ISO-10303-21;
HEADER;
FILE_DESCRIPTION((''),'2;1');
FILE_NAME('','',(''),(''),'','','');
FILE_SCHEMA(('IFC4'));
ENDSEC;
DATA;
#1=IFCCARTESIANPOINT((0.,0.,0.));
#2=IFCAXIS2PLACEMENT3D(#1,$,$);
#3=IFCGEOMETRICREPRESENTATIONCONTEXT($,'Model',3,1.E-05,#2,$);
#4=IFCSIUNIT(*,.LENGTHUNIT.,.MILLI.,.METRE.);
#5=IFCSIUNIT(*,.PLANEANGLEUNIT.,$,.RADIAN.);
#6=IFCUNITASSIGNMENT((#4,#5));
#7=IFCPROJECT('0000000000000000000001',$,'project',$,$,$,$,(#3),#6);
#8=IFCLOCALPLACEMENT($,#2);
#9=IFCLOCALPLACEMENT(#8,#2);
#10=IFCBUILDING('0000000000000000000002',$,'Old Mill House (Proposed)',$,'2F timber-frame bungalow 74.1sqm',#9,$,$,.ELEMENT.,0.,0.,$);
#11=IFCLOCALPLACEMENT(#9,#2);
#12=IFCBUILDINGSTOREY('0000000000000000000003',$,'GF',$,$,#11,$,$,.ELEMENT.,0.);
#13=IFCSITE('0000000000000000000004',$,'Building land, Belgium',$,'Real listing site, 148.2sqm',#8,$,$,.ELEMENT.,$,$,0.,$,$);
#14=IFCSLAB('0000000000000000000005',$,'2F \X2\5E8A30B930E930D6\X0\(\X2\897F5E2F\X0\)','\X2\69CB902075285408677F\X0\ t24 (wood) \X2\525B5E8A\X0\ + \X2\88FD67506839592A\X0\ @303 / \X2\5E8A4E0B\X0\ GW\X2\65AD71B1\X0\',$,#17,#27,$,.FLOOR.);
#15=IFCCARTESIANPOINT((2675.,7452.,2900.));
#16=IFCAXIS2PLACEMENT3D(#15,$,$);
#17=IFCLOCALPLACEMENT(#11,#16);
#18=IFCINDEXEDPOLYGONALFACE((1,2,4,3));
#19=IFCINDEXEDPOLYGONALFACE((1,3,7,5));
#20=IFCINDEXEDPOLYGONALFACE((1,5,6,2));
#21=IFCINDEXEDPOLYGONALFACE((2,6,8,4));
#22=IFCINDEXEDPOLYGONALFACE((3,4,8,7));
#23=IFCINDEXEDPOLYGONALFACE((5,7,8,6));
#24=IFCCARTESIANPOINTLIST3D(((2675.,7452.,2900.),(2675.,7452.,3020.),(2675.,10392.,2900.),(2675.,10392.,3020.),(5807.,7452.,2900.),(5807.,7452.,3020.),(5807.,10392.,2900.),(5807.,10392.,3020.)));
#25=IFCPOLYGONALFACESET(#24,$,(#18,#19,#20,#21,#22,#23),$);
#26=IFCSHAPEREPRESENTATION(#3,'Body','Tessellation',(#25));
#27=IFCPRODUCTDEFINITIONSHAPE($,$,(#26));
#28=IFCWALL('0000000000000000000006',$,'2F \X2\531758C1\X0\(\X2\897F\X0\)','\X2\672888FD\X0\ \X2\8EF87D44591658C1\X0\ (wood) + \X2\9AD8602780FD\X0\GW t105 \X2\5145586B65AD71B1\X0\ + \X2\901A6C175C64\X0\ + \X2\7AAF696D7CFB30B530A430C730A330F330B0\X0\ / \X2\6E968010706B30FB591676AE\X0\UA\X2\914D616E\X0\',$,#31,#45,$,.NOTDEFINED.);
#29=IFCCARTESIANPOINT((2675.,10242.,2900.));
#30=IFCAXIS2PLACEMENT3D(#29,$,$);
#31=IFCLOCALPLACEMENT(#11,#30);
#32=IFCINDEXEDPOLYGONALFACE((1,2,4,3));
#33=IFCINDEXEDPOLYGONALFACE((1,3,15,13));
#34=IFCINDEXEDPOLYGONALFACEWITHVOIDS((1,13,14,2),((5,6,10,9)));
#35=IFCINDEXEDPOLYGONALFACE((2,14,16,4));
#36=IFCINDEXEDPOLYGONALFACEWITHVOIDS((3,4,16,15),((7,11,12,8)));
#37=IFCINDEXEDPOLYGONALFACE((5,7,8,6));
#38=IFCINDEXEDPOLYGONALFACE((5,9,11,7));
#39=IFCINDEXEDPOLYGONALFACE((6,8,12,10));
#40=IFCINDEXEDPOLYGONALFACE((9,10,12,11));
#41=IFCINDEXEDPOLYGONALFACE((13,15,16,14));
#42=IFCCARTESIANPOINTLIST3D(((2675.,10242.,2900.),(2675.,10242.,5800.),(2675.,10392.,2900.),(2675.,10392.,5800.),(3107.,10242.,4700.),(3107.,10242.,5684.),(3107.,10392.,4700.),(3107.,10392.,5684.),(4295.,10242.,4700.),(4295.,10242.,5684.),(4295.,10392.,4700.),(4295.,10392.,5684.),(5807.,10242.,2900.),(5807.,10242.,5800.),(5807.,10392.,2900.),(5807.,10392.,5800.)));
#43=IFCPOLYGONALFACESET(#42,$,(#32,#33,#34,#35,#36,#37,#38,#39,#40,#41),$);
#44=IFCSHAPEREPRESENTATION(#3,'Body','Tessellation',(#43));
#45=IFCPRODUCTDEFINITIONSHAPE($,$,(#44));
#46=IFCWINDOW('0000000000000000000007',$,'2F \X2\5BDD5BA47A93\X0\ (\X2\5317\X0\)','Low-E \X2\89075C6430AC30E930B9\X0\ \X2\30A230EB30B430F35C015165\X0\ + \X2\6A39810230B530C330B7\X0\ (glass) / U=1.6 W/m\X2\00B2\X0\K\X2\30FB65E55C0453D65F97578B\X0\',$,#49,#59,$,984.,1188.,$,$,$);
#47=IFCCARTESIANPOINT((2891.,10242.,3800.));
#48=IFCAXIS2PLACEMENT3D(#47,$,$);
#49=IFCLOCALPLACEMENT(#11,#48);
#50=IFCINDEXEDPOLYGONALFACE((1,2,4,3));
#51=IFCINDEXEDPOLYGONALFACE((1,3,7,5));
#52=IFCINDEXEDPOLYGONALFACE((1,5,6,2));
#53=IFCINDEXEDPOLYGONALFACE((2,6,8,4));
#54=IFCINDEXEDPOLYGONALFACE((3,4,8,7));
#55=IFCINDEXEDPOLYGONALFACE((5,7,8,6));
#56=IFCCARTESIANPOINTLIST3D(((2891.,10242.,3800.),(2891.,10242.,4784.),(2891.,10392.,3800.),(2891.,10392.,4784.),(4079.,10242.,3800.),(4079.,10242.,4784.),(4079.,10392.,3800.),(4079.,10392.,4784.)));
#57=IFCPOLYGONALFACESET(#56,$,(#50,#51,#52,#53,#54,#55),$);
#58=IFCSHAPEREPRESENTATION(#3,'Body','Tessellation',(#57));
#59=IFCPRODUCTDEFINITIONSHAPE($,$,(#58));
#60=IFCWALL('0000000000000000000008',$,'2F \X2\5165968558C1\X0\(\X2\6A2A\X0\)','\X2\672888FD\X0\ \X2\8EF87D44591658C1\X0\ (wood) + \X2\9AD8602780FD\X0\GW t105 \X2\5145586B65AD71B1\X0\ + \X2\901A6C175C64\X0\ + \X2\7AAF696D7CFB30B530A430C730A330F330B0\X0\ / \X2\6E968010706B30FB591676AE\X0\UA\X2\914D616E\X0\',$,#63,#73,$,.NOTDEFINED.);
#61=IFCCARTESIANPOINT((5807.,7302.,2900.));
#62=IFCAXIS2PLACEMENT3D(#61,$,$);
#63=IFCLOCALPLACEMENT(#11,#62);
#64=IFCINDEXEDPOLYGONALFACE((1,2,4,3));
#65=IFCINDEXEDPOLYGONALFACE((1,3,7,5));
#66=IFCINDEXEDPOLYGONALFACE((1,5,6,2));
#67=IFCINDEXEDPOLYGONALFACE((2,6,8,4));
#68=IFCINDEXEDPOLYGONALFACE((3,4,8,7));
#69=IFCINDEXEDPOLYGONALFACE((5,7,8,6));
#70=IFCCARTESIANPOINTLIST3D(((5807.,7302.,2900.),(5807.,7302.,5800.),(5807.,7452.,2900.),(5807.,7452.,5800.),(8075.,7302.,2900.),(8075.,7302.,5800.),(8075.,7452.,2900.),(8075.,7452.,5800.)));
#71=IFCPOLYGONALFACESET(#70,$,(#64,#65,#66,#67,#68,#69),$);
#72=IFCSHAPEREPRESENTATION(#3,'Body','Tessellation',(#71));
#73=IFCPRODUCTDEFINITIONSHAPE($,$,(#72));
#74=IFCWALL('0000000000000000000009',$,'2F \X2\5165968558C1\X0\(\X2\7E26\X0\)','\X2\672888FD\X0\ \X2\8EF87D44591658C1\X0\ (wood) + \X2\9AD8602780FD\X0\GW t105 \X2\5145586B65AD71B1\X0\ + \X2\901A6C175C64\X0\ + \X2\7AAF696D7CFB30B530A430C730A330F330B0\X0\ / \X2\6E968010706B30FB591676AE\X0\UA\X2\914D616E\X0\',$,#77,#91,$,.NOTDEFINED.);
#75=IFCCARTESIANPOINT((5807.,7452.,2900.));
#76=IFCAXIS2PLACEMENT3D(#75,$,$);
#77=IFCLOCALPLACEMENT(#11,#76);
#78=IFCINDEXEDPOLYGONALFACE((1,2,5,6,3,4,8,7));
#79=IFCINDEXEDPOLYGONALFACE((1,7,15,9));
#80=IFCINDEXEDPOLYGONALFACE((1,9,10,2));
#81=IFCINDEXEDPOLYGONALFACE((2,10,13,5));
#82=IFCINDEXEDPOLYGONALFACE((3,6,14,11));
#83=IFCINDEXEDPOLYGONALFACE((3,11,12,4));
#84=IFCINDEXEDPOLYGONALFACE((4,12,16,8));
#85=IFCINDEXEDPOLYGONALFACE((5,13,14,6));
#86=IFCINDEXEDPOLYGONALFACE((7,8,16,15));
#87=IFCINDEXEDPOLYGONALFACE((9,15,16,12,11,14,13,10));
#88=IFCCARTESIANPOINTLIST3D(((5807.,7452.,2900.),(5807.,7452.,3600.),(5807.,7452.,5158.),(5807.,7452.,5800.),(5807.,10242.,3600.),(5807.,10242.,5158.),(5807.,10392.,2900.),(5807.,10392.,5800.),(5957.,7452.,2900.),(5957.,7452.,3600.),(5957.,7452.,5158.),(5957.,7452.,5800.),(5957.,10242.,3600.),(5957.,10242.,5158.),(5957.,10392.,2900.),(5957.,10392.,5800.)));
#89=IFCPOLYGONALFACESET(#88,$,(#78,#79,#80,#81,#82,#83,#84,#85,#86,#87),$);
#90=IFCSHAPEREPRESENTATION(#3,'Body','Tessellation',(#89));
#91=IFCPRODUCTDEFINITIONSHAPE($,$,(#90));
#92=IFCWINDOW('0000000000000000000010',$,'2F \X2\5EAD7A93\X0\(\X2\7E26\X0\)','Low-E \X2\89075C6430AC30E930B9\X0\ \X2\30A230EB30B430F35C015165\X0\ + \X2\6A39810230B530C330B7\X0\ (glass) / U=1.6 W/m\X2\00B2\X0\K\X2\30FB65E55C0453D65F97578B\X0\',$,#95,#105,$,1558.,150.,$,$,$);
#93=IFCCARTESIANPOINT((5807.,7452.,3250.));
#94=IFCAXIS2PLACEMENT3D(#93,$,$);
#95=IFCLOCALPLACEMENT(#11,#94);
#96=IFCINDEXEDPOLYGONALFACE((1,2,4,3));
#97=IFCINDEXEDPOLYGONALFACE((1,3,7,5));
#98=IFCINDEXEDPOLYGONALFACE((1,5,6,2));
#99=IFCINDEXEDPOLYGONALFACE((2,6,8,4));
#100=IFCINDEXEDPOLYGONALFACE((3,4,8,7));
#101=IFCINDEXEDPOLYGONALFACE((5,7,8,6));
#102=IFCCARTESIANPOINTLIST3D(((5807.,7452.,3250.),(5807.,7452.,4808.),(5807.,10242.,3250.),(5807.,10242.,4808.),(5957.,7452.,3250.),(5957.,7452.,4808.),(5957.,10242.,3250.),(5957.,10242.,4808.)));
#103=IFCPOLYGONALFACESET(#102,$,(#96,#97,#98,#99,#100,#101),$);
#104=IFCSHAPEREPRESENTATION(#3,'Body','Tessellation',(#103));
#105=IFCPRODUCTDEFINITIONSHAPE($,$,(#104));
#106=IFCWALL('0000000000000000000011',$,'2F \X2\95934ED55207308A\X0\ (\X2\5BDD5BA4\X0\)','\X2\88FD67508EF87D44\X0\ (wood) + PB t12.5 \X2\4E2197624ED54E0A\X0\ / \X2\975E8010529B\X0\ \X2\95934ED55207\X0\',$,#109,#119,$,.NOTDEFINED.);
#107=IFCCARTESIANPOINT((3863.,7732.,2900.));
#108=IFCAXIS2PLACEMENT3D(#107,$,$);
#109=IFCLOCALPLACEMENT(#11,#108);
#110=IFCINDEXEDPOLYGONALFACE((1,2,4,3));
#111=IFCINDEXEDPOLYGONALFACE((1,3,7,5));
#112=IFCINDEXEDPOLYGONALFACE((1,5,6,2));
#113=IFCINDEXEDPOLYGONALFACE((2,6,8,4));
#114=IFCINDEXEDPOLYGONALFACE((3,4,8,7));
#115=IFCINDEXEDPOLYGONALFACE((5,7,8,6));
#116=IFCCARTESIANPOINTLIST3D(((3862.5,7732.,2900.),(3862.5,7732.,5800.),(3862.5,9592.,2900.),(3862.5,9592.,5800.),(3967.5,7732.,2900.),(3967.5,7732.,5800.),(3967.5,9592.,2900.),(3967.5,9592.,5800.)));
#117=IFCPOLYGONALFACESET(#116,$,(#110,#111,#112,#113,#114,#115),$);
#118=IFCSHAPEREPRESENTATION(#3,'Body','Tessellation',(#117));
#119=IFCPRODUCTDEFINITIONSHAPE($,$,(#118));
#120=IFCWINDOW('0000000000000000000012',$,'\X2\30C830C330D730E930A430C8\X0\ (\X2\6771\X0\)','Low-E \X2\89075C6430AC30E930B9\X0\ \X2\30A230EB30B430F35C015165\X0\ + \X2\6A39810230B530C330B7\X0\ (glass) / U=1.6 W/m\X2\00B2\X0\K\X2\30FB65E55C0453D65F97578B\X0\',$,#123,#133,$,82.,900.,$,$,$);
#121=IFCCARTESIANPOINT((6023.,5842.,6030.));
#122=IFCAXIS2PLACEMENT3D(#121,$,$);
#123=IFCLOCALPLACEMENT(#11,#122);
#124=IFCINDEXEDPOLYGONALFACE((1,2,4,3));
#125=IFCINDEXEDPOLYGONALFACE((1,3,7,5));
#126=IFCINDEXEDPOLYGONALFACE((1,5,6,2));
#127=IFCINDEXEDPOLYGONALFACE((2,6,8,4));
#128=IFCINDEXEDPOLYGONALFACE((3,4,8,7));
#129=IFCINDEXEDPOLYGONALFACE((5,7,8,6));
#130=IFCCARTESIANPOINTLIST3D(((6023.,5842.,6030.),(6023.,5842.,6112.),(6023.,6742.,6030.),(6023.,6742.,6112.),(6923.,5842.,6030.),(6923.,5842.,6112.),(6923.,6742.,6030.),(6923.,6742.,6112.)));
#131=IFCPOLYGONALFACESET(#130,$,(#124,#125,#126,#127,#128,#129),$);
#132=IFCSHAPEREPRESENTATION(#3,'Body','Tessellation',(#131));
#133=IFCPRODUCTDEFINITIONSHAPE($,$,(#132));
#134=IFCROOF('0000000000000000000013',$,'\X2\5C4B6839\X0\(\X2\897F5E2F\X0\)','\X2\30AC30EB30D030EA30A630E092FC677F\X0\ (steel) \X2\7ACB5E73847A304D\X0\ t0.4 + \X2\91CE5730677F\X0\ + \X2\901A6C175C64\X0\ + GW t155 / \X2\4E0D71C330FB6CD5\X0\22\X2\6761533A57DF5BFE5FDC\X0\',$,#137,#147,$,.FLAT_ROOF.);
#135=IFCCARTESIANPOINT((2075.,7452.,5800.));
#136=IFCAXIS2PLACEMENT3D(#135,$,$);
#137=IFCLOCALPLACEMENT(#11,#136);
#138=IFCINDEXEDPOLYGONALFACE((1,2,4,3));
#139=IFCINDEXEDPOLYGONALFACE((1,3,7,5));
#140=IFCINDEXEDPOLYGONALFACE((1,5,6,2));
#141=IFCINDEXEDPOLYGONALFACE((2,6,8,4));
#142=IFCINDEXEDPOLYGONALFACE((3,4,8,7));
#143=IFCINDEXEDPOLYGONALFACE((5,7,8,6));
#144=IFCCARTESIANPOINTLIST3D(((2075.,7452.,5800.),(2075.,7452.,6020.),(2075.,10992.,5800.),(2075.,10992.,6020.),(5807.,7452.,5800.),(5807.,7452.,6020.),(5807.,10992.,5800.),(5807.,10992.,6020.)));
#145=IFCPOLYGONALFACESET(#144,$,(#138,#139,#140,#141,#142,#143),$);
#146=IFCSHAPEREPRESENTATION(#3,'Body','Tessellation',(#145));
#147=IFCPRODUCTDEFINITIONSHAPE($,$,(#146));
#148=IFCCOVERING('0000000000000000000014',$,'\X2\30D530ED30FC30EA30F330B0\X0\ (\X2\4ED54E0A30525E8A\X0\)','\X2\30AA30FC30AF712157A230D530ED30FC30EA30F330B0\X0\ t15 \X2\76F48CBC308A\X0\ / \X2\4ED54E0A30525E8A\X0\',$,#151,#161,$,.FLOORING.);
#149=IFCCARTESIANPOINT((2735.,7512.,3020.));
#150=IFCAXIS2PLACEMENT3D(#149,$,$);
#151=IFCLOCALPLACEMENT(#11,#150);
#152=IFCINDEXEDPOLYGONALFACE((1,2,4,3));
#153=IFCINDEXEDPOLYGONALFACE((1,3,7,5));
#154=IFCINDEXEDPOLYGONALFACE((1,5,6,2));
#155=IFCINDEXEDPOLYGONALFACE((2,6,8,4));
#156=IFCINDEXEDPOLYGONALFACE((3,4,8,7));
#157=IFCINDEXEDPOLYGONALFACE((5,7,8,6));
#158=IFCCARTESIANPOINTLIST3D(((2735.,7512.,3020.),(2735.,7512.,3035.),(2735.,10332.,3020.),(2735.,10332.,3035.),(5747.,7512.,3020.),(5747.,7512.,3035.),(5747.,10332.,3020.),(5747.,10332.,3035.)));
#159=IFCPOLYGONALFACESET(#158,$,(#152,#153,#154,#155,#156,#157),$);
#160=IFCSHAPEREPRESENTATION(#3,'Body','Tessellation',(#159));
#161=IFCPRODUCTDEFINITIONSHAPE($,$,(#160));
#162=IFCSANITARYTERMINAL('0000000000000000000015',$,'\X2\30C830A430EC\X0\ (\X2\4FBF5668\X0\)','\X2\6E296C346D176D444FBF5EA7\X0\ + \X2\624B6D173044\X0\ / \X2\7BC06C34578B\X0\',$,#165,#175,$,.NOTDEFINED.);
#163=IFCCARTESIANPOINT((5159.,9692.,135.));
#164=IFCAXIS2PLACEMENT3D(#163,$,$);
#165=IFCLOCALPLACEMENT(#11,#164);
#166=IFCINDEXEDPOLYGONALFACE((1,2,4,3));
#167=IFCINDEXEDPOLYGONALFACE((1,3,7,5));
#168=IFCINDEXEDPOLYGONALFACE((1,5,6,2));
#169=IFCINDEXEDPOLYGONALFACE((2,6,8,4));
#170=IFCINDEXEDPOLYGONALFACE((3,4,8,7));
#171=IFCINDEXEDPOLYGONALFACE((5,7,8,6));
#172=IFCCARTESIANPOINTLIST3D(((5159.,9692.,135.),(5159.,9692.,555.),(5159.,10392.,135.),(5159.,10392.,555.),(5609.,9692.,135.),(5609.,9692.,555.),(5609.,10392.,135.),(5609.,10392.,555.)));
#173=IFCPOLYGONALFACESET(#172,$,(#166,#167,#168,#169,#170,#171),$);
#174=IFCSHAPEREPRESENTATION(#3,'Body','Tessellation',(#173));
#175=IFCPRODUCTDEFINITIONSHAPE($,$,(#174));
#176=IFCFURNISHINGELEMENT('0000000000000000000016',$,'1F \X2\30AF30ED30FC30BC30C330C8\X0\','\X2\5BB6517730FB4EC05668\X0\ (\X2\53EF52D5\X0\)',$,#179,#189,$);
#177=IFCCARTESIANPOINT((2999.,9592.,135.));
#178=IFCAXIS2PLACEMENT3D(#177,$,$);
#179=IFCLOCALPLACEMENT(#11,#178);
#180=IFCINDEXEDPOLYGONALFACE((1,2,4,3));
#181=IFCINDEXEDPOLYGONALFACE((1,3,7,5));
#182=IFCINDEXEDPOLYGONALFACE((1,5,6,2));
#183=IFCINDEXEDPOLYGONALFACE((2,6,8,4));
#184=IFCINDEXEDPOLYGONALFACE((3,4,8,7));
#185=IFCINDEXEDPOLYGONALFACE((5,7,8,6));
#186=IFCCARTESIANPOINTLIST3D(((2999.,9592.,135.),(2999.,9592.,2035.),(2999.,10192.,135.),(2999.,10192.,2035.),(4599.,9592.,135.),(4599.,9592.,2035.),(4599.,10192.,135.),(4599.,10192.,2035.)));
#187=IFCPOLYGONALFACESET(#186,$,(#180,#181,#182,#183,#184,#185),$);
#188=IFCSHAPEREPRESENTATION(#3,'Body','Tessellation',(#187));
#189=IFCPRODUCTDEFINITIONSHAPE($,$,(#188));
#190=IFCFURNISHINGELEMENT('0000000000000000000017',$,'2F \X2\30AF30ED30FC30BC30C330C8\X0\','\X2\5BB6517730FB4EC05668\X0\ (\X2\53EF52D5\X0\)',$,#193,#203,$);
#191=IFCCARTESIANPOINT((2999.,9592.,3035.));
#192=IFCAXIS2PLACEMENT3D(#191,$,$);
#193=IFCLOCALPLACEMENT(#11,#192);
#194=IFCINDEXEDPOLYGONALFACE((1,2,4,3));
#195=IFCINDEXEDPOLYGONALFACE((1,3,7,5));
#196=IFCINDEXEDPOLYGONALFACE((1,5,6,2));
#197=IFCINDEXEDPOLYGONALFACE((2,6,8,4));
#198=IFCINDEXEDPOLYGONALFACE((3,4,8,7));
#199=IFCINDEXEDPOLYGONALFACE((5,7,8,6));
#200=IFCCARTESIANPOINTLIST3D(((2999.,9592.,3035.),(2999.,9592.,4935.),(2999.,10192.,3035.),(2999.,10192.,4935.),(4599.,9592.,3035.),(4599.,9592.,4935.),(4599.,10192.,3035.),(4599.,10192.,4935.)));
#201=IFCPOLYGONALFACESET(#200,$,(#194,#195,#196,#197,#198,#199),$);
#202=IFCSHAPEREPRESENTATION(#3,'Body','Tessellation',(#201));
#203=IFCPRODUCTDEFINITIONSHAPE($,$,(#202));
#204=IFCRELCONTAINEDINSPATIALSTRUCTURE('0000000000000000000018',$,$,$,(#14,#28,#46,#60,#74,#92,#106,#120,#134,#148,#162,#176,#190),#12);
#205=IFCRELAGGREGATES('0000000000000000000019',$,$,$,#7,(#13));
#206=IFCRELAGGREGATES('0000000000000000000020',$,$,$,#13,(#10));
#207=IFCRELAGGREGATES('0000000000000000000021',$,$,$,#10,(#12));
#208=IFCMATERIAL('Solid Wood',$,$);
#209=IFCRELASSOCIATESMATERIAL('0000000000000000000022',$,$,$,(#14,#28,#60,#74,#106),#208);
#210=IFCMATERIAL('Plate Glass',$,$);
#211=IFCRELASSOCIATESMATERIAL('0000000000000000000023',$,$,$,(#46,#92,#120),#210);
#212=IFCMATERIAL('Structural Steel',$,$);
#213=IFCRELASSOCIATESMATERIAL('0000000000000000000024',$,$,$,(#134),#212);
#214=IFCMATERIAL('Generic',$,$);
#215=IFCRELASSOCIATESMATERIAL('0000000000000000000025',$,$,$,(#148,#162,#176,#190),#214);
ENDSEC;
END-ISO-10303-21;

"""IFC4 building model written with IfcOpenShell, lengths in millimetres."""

from ifc_helpers import new_model, si_unit, frame, frame_2d, origin, place, context, project, spatial, rectangle, extrude, material, element, fill, save


model = new_model("IFC4")

# Units and contexts
model_context = context("Model", 3, precision=1e-05, world=origin())
ifc_project = project(units=[si_unit("LENGTHUNIT", "METRE", prefix="MILLI"), si_unit("PLANEANGLEUNIT", "RADIAN")], contexts=[model_context])

# Site, building, storey
site_placement = place(None, origin())
site = spatial("IfcSite", under=ifc_project, at=site_placement, Name="Building land, Belgium", ObjectType="Real listing site, 148.2sqm", CompositionType="ELEMENT", RefElevation=0.0)
building_placement = place(site_placement, origin())
building = spatial("IfcBuilding", under=site, at=building_placement, Name="Old Mill House (Proposed)", ObjectType="2F timber-frame bungalow 74.1sqm", CompositionType="ELEMENT", ElevationOfRefHeight=0.0, ElevationOfTerrain=0.0)
storey_placement = place(building_placement, origin())
storey = spatial("IfcBuildingStorey", under=building, at=storey_placement, Name="GF", CompositionType="ELEMENT", Elevation=0.0)

# Slab
ifc_material_1 = material(Name="Solid Wood")
slab_placement = place(storey_placement, frame((2675.0, 7452.0, 2900.0)))
element("IfcSlab", 1, at=slab_placement, inside=storey, material=ifc_material_1, Name="2F 床スラブ(西帯)", Description="構造用合板 t24 (wood) 剛床 + 製材根太 @303 / 床下 GW断熱", PredefinedType="FLOOR", context=model_context, shape_type="SweptSolid", body=[
    extrude(rectangle(XDim=3132.0, YDim=2940.0, at=frame_2d((1566.0, 1470.0))), frame((2675.0, 7452.0, 2900.0)), (0.0, 0.0, 1.0), 120.0),
])

# Wall, opening, window
wall_1_placement = place(storey_placement, frame((2675.0, 10242.0, 2900.0)))
wall_1 = element("IfcWall", 2, at=wall_1_placement, inside=storey, material=ifc_material_1, Name="2F 北壁(西)", Description="木製 軸組外壁 (wood) + 高性能GW t105 充填断熱 + 通気層 + 窯業系サイディング / 準耐火・外皮UA配慮", PredefinedType="NOTDEFINED", context=model_context, shape_type="SweptSolid", body=[
    extrude(rectangle(XDim=3132.0, YDim=150.0, at=frame_2d((1566.0, 75.0))), frame((2675.0, 10242.0, 2900.0)), (0.0, 0.0, 1.0), 2900.0),
])
opening_1_placement = place(storey_placement, frame((2891.0, 10242.0, 3800.0)))
opening_1 = element("IfcOpeningElement", 3, at=opening_1_placement, cuts=wall_1, PredefinedType="NOTDEFINED", context=model_context, shape_type="SweptSolid", body=[
    extrude(rectangle(XDim=1188.0, YDim=150.0, at=frame_2d((594.0, 75.0))), frame((2891.0, 10242.0, 3800.0)), (0.0, 0.0, 1.0), 984.0),
])
ifc_material_2 = material(Name="Plate Glass")
window_1_placement = place(storey_placement, frame((2891.0, 10242.0, 3800.0)))
window_1 = element("IfcWindow", 4, at=window_1_placement, inside=storey, material=ifc_material_2, Name="2F 寝室窓 (北)", Description="Low-E 複層ガラス アルゴン封入 + 樹脂サッシ (glass) / U=1.6 W/m²K・日射取得型", OverallHeight=984.0, OverallWidth=1188.0, context=model_context, shape_type="SweptSolid", body=[
    extrude(rectangle(XDim=1188.0, YDim=150.0, at=frame_2d((594.0, 75.0))), frame((2891.0, 10242.0, 3800.0)), (0.0, 0.0, 1.0), 984.0),
])
fill(opening_1, window_1)

# Wall
wall_2_placement = place(storey_placement, frame((5807.0, 7302.0, 2900.0)))
element("IfcWall", 5, at=wall_2_placement, inside=storey, material=ifc_material_1, Name="2F 入隅壁(横)", Description="木製 軸組外壁 (wood) + 高性能GW t105 充填断熱 + 通気層 + 窯業系サイディング / 準耐火・外皮UA配慮", PredefinedType="NOTDEFINED", context=model_context, shape_type="SweptSolid", body=[
    extrude(rectangle(XDim=2268.0, YDim=150.0, at=frame_2d((1134.0, 75.0))), frame((5807.0, 7302.0, 2900.0)), (0.0, 0.0, 1.0), 2900.0),
])

# Wall, opening, window
wall_3_placement = place(storey_placement, frame((5807.0, 7452.0, 2900.0)))
wall_3 = element("IfcWall", 6, at=wall_3_placement, inside=storey, material=ifc_material_1, Name="2F 入隅壁(縦)", Description="木製 軸組外壁 (wood) + 高性能GW t105 充填断熱 + 通気層 + 窯業系サイディング / 準耐火・外皮UA配慮", PredefinedType="NOTDEFINED", context=model_context, shape_type="SweptSolid", body=[
    extrude(rectangle(XDim=150.0, YDim=2940.0, at=frame_2d((75.0, 1470.0))), frame((5807.0, 7452.0, 2900.0)), (0.0, 0.0, 1.0), 2900.0),
])
opening_2_placement = place(storey_placement, frame((5807.0, 7452.0, 3250.0)))
opening_2 = element("IfcOpeningElement", 7, at=opening_2_placement, cuts=wall_3, PredefinedType="NOTDEFINED", context=model_context, shape_type="SweptSolid", body=[
    extrude(rectangle(XDim=150.0, YDim=2790.0, at=frame_2d((75.0, 1395.0))), frame((5807.0, 7452.0, 3250.0)), (0.0, 0.0, 1.0), 1558.0),
])
window_2_placement = place(storey_placement, frame((5807.0, 7452.0, 3250.0)))
window_2 = element("IfcWindow", 8, at=window_2_placement, inside=storey, material=ifc_material_2, Name="2F 庭窓(縦)", Description="Low-E 複層ガラス アルゴン封入 + 樹脂サッシ (glass) / U=1.6 W/m²K・日射取得型", OverallHeight=1558.0, OverallWidth=150.0, context=model_context, shape_type="SweptSolid", body=[
    extrude(rectangle(XDim=150.0, YDim=2790.0, at=frame_2d((75.0, 1395.0))), frame((5807.0, 7452.0, 3250.0)), (0.0, 0.0, 1.0), 1558.0),
])
fill(opening_2, window_2)

# Wall
wall_4_placement = place(storey_placement, frame((3863.0, 7732.0, 2900.0)))
element("IfcWall", 9, at=wall_4_placement, inside=storey, material=ifc_material_1, Name="2F 間仕切り (寝室)", Description="製材軸組 (wood) + PB t12.5 両面仕上 / 非耐力 間仕切", PredefinedType="NOTDEFINED", context=model_context, shape_type="SweptSolid", body=[
    extrude(rectangle(XDim=105.0, YDim=1860.0, at=frame_2d((52.0, 930.0))), frame((3863.0, 7732.0, 2900.0)), (0.0, 0.0, 1.0), 2900.0),
])

# Window
window_3_placement = place(storey_placement, frame((6023.0, 5842.0, 6030.0)))
element("IfcWindow", 10, at=window_3_placement, inside=storey, material=ifc_material_2, Name="トップライト (東)", Description="Low-E 複層ガラス アルゴン封入 + 樹脂サッシ (glass) / U=1.6 W/m²K・日射取得型", OverallHeight=82.0, OverallWidth=900.0, context=model_context, shape_type="SweptSolid", body=[
    extrude(rectangle(XDim=900.0, YDim=900.0, at=frame_2d((450.0, 450.0))), frame((6023.0, 5842.0, 6030.0)), (0.0, 0.0, 1.0), 82.0),
])

# Roof
ifc_material_3 = material(Name="Structural Steel")
for number, where, name in (
    (11, (2075.0, 7452.0, 5800.0), "屋根(西帯)"),
):
    element("IfcRoof", number, at=place(storey_placement, frame(where)), inside=storey, material=ifc_material_3, Name=name, Description="ガルバリウム鋼板 (steel) 立平葺き t0.4 + 野地板 + 通気層 + GW t155 / 不燃・法22条区域対応", PredefinedType="FLAT_ROOF", context=model_context, shape_type="SweptSolid", body=[
        extrude(rectangle(XDim=3732.0, YDim=3540.0, at=frame_2d((1866.0, 1770.0))), frame((2075.0, 7452.0, 5800.0)), (0.0, 0.0, 1.0), 220.0),
    ])

# Covering
ifc_material_4 = material(Name="Generic")
covering_placement = place(storey_placement, frame((2735.0, 7512.0, 3020.0)))
element("IfcCovering", 12, at=covering_placement, inside=storey, material=ifc_material_4, Name="フローリング (仕上げ床)", Description="オーク無垢フローリング t15 直貼り / 仕上げ床", PredefinedType="FLOORING", context=model_context, shape_type="SweptSolid", body=[
    extrude(rectangle(XDim=3012.0, YDim=2820.0, at=frame_2d((1506.0, 1410.0))), frame((2735.0, 7512.0, 3020.0)), (0.0, 0.0, 1.0), 15.0),
])

# Sanitary terminal
sanitary_terminal_placement = place(storey_placement, frame((5159.0, 9692.0, 135.0)))
element("IfcSanitaryTerminal", 13, at=sanitary_terminal_placement, inside=storey, material=ifc_material_4, Name="トイレ (便器)", Description="温水洗浄便座 + 手洗い / 節水型", PredefinedType="NOTDEFINED", context=model_context, shape_type="SweptSolid", body=[
    extrude(rectangle(XDim=450.0, YDim=700.0, at=frame_2d((225.0, 350.0))), frame((5159.0, 9692.0, 135.0)), (0.0, 0.0, 1.0), 420.0),
])

# Furnishing elements
furnishing_1_placement = place(storey_placement, frame((2999.0, 9592.0, 135.0)))
element("IfcFurnishingElement", 14, at=furnishing_1_placement, inside=storey, material=ifc_material_4, Name="1F クローゼット", Description="家具・什器 (可動)", context=model_context, shape_type="SweptSolid", body=[
    extrude(rectangle(XDim=1600.0, YDim=600.0, at=frame_2d((800.0, 300.0))), frame((2999.0, 9592.0, 135.0)), (0.0, 0.0, 1.0), 1900.0),
])
furnishing_2_placement = place(storey_placement, frame((2999.0, 9592.0, 3035.0)))
element("IfcFurnishingElement", 15, at=furnishing_2_placement, inside=storey, material=ifc_material_4, Name="2F クローゼット", Description="家具・什器 (可動)", context=model_context, shape_type="SweptSolid", body=[
    extrude(rectangle(XDim=1600.0, YDim=600.0, at=frame_2d((800.0, 300.0))), frame((2999.0, 9592.0, 3035.0)), (0.0, 0.0, 1.0), 1900.0),
])

save(model, "model.ifc")
